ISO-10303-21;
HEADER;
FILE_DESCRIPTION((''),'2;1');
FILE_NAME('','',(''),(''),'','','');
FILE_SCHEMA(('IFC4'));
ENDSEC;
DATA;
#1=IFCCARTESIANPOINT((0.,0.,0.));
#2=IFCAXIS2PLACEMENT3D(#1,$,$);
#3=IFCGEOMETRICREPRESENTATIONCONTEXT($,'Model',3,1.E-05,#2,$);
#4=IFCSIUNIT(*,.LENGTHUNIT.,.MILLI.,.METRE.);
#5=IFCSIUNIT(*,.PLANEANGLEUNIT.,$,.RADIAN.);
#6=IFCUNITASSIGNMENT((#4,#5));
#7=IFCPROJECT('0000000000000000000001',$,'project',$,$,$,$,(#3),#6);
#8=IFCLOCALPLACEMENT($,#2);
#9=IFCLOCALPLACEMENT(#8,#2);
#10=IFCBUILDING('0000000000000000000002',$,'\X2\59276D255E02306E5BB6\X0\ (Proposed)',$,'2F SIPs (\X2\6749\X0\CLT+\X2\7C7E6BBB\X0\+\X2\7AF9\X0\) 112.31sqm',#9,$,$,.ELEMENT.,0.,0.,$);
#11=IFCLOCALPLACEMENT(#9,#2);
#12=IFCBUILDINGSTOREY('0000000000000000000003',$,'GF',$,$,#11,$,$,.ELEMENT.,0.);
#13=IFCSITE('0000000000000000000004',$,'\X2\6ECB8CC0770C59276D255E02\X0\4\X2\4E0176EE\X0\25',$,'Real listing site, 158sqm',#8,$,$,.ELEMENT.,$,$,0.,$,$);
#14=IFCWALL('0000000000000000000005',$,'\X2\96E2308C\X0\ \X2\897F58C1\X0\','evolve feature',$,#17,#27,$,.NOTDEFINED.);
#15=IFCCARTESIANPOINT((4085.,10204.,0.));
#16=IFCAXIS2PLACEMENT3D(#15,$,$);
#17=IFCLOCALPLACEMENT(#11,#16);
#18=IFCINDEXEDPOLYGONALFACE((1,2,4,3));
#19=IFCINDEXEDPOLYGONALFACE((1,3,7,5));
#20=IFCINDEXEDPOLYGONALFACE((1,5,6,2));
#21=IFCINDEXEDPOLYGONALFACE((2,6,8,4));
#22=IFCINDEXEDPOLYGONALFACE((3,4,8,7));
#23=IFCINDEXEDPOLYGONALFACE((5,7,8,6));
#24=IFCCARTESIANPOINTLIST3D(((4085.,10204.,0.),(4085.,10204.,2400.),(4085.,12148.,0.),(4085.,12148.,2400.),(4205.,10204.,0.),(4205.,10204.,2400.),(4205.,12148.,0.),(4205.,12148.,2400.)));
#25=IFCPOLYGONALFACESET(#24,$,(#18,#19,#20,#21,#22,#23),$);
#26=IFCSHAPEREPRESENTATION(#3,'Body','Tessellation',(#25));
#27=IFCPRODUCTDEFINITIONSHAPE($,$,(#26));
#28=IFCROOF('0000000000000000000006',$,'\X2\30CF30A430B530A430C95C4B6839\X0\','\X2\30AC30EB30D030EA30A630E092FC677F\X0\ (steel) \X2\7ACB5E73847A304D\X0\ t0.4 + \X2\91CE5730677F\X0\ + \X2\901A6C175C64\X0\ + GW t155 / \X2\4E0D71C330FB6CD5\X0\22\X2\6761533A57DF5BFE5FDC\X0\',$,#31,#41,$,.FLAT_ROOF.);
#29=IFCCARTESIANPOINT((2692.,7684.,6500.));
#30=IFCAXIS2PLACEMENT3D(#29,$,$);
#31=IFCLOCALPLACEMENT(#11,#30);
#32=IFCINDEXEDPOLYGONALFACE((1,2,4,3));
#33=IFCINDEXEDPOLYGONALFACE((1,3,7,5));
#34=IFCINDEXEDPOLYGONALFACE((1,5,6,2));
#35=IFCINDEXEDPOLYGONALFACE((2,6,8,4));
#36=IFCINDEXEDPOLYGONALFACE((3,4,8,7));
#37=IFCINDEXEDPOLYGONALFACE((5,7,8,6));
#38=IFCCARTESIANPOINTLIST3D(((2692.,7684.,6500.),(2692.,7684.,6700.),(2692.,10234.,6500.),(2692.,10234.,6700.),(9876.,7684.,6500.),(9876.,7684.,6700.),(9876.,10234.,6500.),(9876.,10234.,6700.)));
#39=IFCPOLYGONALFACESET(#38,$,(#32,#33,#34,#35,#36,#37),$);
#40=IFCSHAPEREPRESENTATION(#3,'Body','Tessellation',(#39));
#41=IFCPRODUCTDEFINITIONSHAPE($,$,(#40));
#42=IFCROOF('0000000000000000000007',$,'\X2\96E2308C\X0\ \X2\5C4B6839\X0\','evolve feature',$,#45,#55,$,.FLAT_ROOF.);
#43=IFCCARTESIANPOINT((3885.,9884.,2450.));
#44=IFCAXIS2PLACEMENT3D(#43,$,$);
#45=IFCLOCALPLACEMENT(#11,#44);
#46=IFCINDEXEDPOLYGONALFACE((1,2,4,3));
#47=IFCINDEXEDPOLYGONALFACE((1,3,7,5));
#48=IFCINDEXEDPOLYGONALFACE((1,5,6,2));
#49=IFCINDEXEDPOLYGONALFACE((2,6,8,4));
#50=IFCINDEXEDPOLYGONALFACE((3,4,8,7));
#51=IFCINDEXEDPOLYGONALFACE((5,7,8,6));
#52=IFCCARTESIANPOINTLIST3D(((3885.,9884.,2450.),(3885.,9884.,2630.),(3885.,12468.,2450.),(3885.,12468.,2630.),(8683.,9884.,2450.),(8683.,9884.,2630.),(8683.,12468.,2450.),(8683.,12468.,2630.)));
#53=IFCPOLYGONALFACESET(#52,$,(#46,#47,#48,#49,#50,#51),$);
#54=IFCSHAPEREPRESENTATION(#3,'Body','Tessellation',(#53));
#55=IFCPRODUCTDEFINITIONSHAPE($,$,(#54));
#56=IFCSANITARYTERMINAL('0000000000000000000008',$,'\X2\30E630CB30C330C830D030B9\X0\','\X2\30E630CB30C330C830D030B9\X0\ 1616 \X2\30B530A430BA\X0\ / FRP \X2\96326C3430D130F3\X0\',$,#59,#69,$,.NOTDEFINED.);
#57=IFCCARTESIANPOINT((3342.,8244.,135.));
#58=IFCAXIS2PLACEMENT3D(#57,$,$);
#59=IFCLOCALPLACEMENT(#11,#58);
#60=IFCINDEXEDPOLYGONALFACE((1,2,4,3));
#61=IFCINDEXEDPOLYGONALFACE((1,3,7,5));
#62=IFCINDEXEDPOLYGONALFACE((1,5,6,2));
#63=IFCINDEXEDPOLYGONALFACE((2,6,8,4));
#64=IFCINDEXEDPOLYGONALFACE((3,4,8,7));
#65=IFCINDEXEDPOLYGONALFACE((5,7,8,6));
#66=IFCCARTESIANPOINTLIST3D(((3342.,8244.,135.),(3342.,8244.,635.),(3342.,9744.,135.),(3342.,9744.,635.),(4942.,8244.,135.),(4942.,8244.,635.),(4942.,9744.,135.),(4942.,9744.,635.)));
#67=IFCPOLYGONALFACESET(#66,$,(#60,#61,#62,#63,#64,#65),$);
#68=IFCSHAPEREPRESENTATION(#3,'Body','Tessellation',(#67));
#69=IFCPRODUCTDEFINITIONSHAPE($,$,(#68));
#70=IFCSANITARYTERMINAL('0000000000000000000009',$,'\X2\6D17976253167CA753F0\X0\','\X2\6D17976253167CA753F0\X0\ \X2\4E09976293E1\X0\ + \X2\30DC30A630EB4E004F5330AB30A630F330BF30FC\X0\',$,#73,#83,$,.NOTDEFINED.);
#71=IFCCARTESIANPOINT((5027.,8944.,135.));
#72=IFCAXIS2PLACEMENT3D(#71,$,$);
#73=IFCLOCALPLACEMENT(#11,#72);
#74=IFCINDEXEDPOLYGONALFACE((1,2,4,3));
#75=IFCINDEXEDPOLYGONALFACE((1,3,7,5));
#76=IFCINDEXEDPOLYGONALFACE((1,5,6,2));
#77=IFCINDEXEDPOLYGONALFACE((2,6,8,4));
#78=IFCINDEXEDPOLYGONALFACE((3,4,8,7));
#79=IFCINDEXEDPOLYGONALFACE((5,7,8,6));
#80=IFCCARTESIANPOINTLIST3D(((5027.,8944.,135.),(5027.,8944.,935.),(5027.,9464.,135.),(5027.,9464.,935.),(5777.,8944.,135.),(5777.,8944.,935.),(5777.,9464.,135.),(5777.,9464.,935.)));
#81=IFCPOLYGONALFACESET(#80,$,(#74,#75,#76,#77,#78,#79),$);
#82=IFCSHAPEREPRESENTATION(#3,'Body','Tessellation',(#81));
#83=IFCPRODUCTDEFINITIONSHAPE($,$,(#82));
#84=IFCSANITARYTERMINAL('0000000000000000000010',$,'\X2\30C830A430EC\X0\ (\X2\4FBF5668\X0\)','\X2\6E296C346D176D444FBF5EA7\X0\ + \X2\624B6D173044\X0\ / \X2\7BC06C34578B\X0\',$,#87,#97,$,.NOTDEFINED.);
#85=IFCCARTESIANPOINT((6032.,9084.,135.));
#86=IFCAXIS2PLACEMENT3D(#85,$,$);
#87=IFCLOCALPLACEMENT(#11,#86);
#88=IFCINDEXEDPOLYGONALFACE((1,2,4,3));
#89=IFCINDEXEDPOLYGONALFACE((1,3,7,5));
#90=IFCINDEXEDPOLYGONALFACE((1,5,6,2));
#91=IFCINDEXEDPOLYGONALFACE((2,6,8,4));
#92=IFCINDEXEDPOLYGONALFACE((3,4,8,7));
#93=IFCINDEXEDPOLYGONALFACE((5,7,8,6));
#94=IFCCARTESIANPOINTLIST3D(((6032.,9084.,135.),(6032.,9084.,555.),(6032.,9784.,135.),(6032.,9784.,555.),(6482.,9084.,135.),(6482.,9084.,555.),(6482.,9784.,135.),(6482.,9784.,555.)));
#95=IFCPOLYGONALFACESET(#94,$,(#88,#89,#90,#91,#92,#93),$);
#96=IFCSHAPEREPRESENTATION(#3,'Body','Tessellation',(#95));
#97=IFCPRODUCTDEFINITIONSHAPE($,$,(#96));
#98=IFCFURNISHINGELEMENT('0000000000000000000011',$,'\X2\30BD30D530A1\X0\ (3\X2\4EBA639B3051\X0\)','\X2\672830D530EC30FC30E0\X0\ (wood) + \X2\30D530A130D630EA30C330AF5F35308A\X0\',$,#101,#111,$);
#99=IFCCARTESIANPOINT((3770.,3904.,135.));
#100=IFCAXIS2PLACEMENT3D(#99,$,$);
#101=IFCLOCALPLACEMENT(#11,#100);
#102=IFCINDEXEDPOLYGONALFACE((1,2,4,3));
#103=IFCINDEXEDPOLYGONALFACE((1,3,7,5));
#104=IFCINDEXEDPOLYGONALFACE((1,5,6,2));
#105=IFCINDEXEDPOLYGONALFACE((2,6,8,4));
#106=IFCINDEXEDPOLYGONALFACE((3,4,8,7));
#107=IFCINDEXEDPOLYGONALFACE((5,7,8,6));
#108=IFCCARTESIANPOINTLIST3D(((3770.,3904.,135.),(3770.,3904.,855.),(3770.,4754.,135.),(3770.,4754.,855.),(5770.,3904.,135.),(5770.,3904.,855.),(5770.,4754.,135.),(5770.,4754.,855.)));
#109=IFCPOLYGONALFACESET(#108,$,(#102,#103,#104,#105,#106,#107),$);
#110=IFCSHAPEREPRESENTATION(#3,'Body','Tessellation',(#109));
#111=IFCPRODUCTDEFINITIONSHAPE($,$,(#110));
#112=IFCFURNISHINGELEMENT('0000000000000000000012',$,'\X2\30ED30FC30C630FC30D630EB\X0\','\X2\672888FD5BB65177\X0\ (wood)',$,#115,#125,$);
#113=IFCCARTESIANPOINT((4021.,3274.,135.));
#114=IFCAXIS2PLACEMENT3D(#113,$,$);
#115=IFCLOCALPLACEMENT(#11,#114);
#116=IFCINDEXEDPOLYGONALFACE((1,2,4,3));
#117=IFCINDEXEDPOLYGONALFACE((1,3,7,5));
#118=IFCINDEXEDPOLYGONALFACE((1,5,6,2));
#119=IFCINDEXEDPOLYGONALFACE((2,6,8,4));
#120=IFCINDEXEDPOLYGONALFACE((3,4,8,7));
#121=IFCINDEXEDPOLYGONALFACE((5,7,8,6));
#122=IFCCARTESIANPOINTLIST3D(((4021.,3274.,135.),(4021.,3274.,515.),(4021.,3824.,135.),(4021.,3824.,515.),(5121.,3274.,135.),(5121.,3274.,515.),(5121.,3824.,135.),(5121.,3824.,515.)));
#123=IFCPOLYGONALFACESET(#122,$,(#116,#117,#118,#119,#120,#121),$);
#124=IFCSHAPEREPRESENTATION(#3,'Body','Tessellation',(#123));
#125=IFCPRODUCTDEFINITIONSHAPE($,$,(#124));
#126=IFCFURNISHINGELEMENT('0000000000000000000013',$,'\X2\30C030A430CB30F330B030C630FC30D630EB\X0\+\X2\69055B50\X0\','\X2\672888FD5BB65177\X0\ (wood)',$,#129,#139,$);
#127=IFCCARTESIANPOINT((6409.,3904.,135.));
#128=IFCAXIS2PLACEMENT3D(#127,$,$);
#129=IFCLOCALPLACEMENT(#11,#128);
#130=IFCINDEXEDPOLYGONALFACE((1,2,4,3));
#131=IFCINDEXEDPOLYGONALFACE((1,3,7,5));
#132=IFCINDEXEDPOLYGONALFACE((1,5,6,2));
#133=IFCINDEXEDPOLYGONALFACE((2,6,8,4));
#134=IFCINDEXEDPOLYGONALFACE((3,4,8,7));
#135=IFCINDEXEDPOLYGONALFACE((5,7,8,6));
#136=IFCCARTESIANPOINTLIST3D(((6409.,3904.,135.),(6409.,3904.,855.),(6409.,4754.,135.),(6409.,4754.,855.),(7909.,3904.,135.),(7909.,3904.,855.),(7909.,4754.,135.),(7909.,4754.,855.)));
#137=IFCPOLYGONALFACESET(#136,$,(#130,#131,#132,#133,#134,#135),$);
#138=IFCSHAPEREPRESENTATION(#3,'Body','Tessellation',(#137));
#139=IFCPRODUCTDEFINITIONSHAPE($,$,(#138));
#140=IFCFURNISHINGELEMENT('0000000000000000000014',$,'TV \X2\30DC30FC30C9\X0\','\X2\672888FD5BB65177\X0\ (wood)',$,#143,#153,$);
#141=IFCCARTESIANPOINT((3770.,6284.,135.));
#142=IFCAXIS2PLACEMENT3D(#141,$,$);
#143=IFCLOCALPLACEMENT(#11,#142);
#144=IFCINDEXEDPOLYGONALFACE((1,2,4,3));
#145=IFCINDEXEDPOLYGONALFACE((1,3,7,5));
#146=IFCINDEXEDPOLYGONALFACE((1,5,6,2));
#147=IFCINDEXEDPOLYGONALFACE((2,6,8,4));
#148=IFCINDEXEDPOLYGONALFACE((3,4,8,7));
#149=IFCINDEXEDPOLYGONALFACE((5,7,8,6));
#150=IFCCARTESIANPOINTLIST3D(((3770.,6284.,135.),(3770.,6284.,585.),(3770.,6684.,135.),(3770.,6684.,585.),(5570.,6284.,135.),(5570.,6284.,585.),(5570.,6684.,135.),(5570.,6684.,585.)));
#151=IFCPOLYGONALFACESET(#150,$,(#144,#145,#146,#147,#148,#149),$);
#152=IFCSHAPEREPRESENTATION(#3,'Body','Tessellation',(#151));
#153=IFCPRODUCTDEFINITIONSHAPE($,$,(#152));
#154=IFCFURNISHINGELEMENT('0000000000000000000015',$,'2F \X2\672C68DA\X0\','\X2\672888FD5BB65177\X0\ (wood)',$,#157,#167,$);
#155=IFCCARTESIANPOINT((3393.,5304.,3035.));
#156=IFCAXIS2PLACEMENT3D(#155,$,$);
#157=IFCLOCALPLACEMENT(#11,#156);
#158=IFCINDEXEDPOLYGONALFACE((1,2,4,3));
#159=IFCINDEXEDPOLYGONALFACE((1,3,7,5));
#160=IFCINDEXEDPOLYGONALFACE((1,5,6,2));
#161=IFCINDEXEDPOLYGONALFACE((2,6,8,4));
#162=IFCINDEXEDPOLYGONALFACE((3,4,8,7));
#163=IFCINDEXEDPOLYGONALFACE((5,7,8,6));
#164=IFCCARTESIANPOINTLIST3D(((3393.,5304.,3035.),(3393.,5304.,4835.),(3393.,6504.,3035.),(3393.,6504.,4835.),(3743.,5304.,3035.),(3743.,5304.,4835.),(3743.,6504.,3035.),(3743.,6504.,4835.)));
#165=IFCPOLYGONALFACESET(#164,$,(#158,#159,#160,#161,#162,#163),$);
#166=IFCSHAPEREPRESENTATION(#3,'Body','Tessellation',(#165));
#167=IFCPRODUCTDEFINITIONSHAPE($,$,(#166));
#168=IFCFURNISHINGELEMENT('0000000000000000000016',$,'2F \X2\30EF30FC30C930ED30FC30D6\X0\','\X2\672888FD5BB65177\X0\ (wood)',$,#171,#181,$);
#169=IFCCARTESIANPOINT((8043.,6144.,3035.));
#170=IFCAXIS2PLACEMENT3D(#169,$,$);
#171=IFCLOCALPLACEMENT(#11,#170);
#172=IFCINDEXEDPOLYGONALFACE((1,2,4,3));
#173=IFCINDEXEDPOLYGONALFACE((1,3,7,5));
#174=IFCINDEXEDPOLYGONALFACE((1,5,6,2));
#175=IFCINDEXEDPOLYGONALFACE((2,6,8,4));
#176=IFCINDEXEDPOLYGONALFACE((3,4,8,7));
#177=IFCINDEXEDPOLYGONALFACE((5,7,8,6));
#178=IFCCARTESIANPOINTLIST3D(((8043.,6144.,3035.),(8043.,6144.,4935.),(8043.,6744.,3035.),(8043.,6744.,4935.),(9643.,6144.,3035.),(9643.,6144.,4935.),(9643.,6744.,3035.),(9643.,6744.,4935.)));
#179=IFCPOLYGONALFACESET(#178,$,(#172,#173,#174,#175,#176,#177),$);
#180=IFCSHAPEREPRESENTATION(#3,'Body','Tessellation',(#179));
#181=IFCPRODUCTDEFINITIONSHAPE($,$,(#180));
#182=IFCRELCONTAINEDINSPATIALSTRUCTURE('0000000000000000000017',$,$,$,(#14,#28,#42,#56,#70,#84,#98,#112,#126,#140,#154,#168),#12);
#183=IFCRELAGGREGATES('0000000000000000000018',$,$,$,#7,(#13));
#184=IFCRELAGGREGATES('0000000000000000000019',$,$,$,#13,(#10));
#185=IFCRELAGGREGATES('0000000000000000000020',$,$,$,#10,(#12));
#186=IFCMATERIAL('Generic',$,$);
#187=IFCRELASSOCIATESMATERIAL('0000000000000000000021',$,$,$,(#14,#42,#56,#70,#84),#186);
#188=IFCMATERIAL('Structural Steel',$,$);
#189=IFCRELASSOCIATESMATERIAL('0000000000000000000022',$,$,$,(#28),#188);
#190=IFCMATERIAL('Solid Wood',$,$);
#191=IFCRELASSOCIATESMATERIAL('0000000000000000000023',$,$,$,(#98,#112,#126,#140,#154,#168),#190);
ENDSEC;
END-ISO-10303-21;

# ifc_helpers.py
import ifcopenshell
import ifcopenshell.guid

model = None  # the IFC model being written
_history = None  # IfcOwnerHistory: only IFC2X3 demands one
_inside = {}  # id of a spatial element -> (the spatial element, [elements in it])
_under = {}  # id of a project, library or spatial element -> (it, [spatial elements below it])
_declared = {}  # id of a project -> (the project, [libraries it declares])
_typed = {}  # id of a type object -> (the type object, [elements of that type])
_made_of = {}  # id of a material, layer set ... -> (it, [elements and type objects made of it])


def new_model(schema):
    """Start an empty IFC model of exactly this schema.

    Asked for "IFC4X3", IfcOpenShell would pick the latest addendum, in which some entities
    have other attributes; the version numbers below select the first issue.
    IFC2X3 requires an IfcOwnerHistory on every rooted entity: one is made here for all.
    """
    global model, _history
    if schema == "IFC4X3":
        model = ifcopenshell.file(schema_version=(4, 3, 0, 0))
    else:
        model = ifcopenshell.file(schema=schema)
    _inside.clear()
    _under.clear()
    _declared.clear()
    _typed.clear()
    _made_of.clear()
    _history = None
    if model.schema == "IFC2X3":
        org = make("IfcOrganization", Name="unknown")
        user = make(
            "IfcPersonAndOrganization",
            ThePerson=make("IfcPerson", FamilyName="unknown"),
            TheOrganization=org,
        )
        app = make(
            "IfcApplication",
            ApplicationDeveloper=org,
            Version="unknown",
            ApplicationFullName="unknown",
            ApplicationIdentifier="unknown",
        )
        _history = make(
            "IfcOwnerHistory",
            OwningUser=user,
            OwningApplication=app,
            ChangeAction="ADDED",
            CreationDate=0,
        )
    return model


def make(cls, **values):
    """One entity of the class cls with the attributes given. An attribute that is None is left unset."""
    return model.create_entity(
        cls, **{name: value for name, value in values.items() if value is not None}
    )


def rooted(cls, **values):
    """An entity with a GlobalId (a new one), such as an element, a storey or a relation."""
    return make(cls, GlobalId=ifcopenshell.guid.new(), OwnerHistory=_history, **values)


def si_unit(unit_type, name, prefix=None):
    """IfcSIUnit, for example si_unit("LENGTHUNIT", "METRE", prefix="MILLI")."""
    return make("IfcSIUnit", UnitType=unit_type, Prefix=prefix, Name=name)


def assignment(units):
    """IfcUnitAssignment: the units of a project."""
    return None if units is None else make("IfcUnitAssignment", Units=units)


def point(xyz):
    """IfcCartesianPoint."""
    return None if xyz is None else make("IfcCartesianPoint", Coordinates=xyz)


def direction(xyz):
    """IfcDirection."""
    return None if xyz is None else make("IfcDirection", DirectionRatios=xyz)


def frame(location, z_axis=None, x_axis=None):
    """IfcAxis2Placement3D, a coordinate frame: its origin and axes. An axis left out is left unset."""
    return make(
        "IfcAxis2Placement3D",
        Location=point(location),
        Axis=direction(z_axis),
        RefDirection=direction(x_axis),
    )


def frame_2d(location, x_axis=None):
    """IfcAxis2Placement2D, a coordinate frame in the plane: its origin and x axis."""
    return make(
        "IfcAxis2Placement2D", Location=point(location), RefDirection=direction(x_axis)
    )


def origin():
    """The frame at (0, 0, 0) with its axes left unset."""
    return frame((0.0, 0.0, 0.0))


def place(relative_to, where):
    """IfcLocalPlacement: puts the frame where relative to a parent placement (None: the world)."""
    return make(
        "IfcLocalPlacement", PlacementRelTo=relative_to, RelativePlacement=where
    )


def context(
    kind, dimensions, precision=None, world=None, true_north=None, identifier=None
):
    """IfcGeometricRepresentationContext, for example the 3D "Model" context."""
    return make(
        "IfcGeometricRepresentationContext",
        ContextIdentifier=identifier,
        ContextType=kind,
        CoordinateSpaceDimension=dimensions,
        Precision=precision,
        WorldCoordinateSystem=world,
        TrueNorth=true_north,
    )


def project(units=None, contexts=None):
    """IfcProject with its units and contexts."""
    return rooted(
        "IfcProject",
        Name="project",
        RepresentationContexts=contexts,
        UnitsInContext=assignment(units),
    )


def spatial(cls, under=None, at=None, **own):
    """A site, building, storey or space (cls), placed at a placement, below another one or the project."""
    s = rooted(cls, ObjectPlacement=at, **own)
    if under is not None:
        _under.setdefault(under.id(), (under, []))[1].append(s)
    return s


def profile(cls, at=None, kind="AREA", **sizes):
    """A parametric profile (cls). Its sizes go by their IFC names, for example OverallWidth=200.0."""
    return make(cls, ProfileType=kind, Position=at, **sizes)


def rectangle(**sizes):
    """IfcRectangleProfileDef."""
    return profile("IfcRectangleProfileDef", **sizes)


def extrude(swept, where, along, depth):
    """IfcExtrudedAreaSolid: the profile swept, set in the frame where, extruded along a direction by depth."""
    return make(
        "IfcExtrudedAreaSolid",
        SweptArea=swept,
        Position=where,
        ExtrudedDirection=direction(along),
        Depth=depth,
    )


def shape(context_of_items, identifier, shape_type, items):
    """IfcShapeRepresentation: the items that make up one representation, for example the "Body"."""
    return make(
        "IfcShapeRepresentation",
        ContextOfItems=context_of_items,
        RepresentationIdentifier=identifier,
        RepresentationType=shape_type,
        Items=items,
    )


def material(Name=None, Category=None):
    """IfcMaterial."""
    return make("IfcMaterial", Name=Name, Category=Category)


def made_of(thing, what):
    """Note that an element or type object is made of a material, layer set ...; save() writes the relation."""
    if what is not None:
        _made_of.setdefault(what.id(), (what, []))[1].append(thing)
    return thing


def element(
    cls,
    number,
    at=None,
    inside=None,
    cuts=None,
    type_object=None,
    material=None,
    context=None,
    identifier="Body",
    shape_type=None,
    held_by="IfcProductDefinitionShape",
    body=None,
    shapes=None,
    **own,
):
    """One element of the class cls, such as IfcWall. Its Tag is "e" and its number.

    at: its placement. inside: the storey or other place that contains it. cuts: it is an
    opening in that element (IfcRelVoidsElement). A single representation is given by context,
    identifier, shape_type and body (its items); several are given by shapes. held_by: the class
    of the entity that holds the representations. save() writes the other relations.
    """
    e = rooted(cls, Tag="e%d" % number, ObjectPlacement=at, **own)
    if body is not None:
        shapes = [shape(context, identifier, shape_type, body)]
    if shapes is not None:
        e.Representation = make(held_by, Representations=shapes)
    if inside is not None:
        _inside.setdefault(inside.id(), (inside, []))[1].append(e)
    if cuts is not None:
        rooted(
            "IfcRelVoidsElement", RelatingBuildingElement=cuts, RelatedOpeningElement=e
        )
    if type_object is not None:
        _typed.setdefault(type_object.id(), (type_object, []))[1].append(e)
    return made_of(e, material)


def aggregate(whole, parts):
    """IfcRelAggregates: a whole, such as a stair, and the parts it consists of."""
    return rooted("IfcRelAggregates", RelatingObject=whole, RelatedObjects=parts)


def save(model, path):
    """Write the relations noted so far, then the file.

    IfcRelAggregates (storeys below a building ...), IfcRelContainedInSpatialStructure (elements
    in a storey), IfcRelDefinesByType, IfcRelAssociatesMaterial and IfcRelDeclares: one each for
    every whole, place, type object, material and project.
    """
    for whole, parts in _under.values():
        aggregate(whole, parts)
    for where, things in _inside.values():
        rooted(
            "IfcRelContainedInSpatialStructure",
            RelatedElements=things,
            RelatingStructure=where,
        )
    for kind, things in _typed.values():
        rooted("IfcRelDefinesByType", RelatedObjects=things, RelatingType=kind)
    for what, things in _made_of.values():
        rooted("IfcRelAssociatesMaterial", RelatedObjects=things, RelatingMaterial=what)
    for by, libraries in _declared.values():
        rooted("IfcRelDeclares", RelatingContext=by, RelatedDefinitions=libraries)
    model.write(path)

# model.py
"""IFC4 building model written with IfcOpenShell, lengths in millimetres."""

from ifc_helpers import new_model, si_unit, frame, frame_2d, origin, place, context, project, spatial, rectangle, extrude, material, element, save


model = new_model("IFC4")

# Units and contexts
model_context = context("Model", 3, precision=1e-05, world=origin())
ifc_project = project(units=[si_unit("LENGTHUNIT", "METRE", prefix="MILLI"), si_unit("PLANEANGLEUNIT", "RADIAN")], contexts=[model_context])

# Site, building, storey
site_placement = place(None, origin())
site = spatial("IfcSite", under=ifc_project, at=site_placement, Name="滋賀県大津市4丁目25", ObjectType="Real listing site, 158sqm", CompositionType="ELEMENT", RefElevation=0.0)
building_placement = place(site_placement, origin())
building = spatial("IfcBuilding", under=site, at=building_placement, Name="大津市の家 (Proposed)", ObjectType="2F SIPs (杉CLT+籾殻+竹) 112.31sqm", CompositionType="ELEMENT", ElevationOfRefHeight=0.0, ElevationOfTerrain=0.0)
storey_placement = place(building_placement, origin())
storey = spatial("IfcBuildingStorey", under=building, at=storey_placement, Name="GF", CompositionType="ELEMENT", Elevation=0.0)

# Shared definitions
ifc_material_1 = material(Name="Generic")

# Shared definitions
ifc_material_2 = material(Name="Solid Wood")

# Wall
wall_1_placement = place(storey_placement, frame((4085.0, 10204.0, 0.0)))
element("IfcWall", 1, at=wall_1_placement, inside=storey, material=ifc_material_1, Name="離れ 西壁", Description="evolve feature", PredefinedType="NOTDEFINED", context=model_context, shape_type="SweptSolid", body=[
    extrude(rectangle(XDim=120.0, YDim=1944.0, at=frame_2d((60.0, 972.0))), frame((4085.0, 10204.0, 0.0)), (0.0, 0.0, 1.0), 2400.0),
])

# Roofs
ifc_material_3 = material(Name="Structural Steel")
roof_1_placement = place(storey_placement, frame((2692.0, 7684.0, 6500.0)))
element("IfcRoof", 2, at=roof_1_placement, inside=storey, material=ifc_material_3, Name="ハイサイド屋根", Description="ガルバリウム鋼板 (steel) 立平葺き t0.4 + 野地板 + 通気層 + GW t155 / 不燃・法22条区域対応", PredefinedType="FLAT_ROOF", context=model_context, shape_type="SweptSolid", body=[
    extrude(rectangle(XDim=7184.0, YDim=2550.0, at=frame_2d((3592.0, 1275.0))), frame((2692.0, 7684.0, 6500.0)), (0.0, 0.0, 1.0), 200.0),
])
roof_2_placement = place(storey_placement, frame((3885.0, 9884.0, 2450.0)))
element("IfcRoof", 3, at=roof_2_placement, inside=storey, material=ifc_material_1, Name="離れ 屋根", Description="evolve feature", PredefinedType="FLAT_ROOF", context=model_context, shape_type="SweptSolid", body=[
    extrude(rectangle(XDim=4798.0, YDim=2584.0, at=frame_2d((2399.0, 1292.0))), frame((3885.0, 9884.0, 2450.0)), (0.0, 0.0, 1.0), 180.0),
])

# Sanitary terminals
sanitary_terminal_1_placement = place(storey_placement, frame((3342.0, 8244.0, 135.0)))
element("IfcSanitaryTerminal", 4, at=sanitary_terminal_1_placement, inside=storey, material=ifc_material_1, Name="ユニットバス", Description="ユニットバス 1616 サイズ / FRP 防水パン", PredefinedType="NOTDEFINED", context=model_context, shape_type="SweptSolid", body=[
    extrude(rectangle(XDim=1600.0, YDim=1500.0, at=frame_2d((800.0, 750.0))), frame((3342.0, 8244.0, 135.0)), (0.0, 0.0, 1.0), 500.0),
])
sanitary_terminal_2_placement = place(storey_placement, frame((5027.0, 8944.0, 135.0)))
element("IfcSanitaryTerminal", 5, at=sanitary_terminal_2_placement, inside=storey, material=ifc_material_1, Name="洗面化粧台", Description="洗面化粧台 三面鏡 + ボウル一体カウンター", PredefinedType="NOTDEFINED", context=model_context, shape_type="SweptSolid", body=[
    extrude(rectangle(XDim=750.0, YDim=520.0, at=frame_2d((375.0, 260.0))), frame((5027.0, 8944.0, 135.0)), (0.0, 0.0, 1.0), 800.0),
])
sanitary_terminal_3_placement = place(storey_placement, frame((6032.0, 9084.0, 135.0)))
element("IfcSanitaryTerminal", 6, at=sanitary_terminal_3_placement, inside=storey, material=ifc_material_1, Name="トイレ (便器)", Description="温水洗浄便座 + 手洗い / 節水型", PredefinedType="NOTDEFINED", context=model_context, shape_type="SweptSolid", body=[
    extrude(rectangle(XDim=450.0, YDim=700.0, at=frame_2d((225.0, 350.0))), frame((6032.0, 9084.0, 135.0)), (0.0, 0.0, 1.0), 420.0),
])

# Furnishing elements
furnishing_1_placement = place(storey_placement, frame((3770.0, 3904.0, 135.0)))
element("IfcFurnishingElement", 7, at=furnishing_1_placement, inside=storey, material=ifc_material_2, Name="ソファ (3人掛け)", Description="木フレーム (wood) + ファブリック張り", context=model_context, shape_type="SweptSolid", body=[
    extrude(rectangle(XDim=2000.0, YDim=850.0, at=frame_2d((1000.0, 425.0))), frame((3770.0, 3904.0, 135.0)), (0.0, 0.0, 1.0), 720.0),
])
furnishing_2_placement = place(storey_placement, frame((4021.0, 3274.0, 135.0)))
element("IfcFurnishingElement", 8, at=furnishing_2_placement, inside=storey, material=ifc_material_2, Name="ローテーブル", Description="木製家具 (wood)", context=model_context, shape_type="SweptSolid", body=[
    extrude(rectangle(XDim=1100.0, YDim=550.0, at=frame_2d((550.0, 275.0))), frame((4021.0, 3274.0, 135.0)), (0.0, 0.0, 1.0), 380.0),
])
furnishing_3_placement = place(storey_placement, frame((6409.0, 3904.0, 135.0)))
element("IfcFurnishingElement", 9, at=furnishing_3_placement, inside=storey, material=ifc_material_2, Name="ダイニングテーブル+椅子", Description="木製家具 (wood)", context=model_context, shape_type="SweptSolid", body=[
    extrude(rectangle(XDim=1500.0, YDim=850.0, at=frame_2d((750.0, 425.0))), frame((6409.0, 3904.0, 135.0)), (0.0, 0.0, 1.0), 720.0),
])
furnishing_4_placement = place(storey_placement, frame((3770.0, 6284.0, 135.0)))
element("IfcFurnishingElement", 10, at=furnishing_4_placement, inside=storey, material=ifc_material_2, Name="TV ボード", Description="木製家具 (wood)", context=model_context, shape_type="SweptSolid", body=[
    extrude(rectangle(XDim=1800.0, YDim=400.0, at=frame_2d((900.0, 200.0))), frame((3770.0, 6284.0, 135.0)), (0.0, 0.0, 1.0), 450.0),
])
furnishing_5_placement = place(storey_placement, frame((3393.0, 5304.0, 3035.0)))
element("IfcFurnishingElement", 11, at=furnishing_5_placement, inside=storey, material=ifc_material_2, Name="2F 本棚", Description="木製家具 (wood)", context=model_context, shape_type="SweptSolid", body=[
    extrude(rectangle(XDim=350.0, YDim=1200.0, at=frame_2d((175.0, 600.0))), frame((3393.0, 5304.0, 3035.0)), (0.0, 0.0, 1.0), 1800.0),
])
furnishing_6_placement = place(storey_placement, frame((8043.0, 6144.0, 3035.0)))
element("IfcFurnishingElement", 12, at=furnishing_6_placement, inside=storey, material=ifc_material_2, Name="2F ワードローブ", Description="木製家具 (wood)", context=model_context, shape_type="SweptSolid", body=[
    extrude(rectangle(XDim=1600.0, YDim=600.0, at=frame_2d((800.0, 300.0))), frame((8043.0, 6144.0, 3035.0)), (0.0, 0.0, 1.0), 1900.0),
])

save(model, "model.ifc")
